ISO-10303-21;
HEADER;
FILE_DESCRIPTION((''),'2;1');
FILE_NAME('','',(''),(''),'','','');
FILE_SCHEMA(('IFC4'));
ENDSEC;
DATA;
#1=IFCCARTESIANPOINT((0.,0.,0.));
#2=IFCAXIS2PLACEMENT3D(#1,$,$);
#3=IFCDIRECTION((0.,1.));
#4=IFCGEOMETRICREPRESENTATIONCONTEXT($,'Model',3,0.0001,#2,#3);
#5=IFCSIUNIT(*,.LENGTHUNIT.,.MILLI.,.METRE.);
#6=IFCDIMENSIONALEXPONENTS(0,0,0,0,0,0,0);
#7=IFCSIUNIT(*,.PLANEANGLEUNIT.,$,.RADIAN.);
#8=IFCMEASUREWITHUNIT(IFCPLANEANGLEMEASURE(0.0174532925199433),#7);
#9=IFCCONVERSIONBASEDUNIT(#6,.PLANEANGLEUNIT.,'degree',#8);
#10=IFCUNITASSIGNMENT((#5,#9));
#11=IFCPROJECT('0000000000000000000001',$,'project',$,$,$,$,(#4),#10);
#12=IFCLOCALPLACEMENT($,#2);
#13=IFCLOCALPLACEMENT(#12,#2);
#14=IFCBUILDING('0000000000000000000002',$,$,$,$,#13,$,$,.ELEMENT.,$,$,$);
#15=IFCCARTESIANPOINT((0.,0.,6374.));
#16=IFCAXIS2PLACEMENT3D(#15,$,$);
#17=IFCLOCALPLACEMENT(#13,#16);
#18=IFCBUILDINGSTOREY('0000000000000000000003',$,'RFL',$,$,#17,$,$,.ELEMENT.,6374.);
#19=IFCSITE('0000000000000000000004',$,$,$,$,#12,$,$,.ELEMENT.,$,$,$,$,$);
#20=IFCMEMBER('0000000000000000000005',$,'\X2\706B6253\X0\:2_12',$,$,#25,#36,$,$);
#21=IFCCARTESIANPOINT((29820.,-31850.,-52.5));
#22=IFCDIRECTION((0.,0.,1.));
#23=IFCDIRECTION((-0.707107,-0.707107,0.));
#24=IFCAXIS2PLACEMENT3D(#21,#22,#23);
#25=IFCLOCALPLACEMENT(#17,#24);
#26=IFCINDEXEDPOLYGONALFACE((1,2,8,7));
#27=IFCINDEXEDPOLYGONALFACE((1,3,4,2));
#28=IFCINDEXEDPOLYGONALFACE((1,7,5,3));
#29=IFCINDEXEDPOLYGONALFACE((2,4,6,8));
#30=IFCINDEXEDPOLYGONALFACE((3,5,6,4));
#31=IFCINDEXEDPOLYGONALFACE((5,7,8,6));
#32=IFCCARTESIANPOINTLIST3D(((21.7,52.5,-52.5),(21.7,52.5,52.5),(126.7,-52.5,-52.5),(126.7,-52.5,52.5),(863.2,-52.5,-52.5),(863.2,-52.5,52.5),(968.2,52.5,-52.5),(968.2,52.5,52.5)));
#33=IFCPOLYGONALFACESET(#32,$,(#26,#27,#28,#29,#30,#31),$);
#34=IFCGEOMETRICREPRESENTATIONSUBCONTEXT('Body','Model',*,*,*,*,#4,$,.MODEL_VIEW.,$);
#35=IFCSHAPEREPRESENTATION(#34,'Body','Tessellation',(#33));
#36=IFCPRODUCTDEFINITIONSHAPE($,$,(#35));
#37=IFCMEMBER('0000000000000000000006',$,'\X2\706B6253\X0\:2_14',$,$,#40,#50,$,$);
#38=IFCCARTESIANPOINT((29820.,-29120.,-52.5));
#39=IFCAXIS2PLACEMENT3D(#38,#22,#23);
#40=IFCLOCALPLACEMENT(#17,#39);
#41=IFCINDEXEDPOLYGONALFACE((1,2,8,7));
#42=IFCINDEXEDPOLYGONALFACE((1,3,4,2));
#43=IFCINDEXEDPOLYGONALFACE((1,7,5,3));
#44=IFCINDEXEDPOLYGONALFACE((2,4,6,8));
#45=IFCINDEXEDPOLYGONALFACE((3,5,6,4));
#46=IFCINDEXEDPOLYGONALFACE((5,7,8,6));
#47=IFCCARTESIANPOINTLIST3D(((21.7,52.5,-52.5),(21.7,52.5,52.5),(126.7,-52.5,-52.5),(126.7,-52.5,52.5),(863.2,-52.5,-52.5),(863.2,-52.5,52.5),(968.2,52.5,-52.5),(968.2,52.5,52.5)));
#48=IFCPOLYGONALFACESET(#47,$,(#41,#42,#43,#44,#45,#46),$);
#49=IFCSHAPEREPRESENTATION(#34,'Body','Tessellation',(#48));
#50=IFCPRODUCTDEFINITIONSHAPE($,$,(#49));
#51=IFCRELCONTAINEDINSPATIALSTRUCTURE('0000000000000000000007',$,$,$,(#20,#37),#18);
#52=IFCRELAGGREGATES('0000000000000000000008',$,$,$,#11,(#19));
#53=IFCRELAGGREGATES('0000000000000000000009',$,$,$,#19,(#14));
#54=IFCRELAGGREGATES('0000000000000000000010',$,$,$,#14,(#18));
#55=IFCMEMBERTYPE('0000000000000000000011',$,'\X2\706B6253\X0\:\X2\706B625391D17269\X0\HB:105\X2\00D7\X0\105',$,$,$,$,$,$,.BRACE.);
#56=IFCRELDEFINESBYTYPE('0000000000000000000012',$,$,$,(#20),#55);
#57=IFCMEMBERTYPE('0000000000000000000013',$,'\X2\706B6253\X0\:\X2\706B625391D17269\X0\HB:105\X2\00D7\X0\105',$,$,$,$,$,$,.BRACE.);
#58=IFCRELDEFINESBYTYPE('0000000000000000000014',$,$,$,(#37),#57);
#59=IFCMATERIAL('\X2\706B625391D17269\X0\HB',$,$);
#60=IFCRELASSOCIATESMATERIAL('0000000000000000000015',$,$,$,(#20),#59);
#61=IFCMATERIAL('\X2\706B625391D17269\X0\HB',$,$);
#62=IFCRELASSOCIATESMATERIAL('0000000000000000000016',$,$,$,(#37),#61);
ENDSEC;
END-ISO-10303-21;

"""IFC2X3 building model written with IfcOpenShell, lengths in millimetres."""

from ifc_helpers import new_model, entity, si_unit, converted_unit, direction, frame, origin, place, context, subcontext, project, spatial, polyline, outline, extrude, material, type_object, element, save


model = new_model("IFC2X3")

# Units and contexts
model_context = context("Model", 3, precision=0.0001, world=origin(), true_north=direction((0.0, 1.0)))
body_context = subcontext(model_context, "Body", "Model", "MODEL_VIEW")
ifc_project = project(units=[si_unit("LENGTHUNIT", "METRE", prefix="MILLI"), converted_unit("PLANEANGLEUNIT", "degree", entity("IfcPlaneAngleMeasure", 0.0174532925199433), si_unit("PLANEANGLEUNIT", "RADIAN"), dimensions=[0, 0, 0, 0, 0, 0, 0])], contexts=[model_context])

# Site, building, storey
site_placement = place(None, origin())
site = spatial("IfcSite", under=ifc_project, at=site_placement, CompositionType="ELEMENT")
building_placement = place(site_placement, origin())
building = spatial("IfcBuilding", under=site, at=building_placement, CompositionType="ELEMENT")
storey_placement = place(building_placement, frame((0.0, 0.0, 6374.0)))
storey = spatial("IfcBuildingStorey", under=building, at=storey_placement, Name="RFL", CompositionType="ELEMENT", Elevation=6374.0)

# Members
ifc_material_1 = material(Name="火打金物HB")
member_type_1 = type_object("IfcMemberType", Name="火打:火打金物HB:105×105", PredefinedType="BRACE")
member_1_placement = place(storey_placement, frame((29820.0, -31850.0, -52.5), z_axis=(0.0, 0.0, 1.0), x_axis=(-0.707107, -0.707107, 0.0)))
element("IfcMember", 1, at=member_1_placement, inside=storey, type_object=member_type_1, material=ifc_material_1, Name="火打:2_12", context=body_context, shape_type="SweptSolid", body=[
    extrude(outline(polyline([(126.7, -52.5, 0.0), (21.7, 52.5, 0.0), (968.2, 52.5, 0.0), (863.2, -52.5, 0.0), (126.7, -52.5, 0.0)])), frame((0.0, 0.0, -52.5), z_axis=(0.0, 0.0, 1.0), x_axis=(1.0, 0.0, 0.0)), (0.0, 0.0, 1.0), 105.0),
])
ifc_material_2 = material(Name="火打金物HB")
member_type_2 = type_object("IfcMemberType", Name="火打:火打金物HB:105×105", PredefinedType="BRACE")
member_2_placement = place(storey_placement, frame((29820.0, -29120.0, -52.5), z_axis=(0.0, 0.0, 1.0), x_axis=(-0.707107, -0.707107, 0.0)))
element("IfcMember", 2, at=member_2_placement, inside=storey, type_object=member_type_2, material=ifc_material_2, Name="火打:2_14", context=body_context, shape_type="SweptSolid", body=[
    extrude(outline(polyline([(126.7, -52.5, 0.0), (21.7, 52.5, 0.0), (968.2, 52.5, 0.0), (863.2, -52.5, 0.0), (126.7, -52.5, 0.0)])), frame((0.0, 0.0, -52.5), z_axis=(0.0, 0.0, 1.0), x_axis=(1.0, 0.0, 0.0)), (0.0, 0.0, 1.0), 105.0),
])

save(model, "model.ifc")
